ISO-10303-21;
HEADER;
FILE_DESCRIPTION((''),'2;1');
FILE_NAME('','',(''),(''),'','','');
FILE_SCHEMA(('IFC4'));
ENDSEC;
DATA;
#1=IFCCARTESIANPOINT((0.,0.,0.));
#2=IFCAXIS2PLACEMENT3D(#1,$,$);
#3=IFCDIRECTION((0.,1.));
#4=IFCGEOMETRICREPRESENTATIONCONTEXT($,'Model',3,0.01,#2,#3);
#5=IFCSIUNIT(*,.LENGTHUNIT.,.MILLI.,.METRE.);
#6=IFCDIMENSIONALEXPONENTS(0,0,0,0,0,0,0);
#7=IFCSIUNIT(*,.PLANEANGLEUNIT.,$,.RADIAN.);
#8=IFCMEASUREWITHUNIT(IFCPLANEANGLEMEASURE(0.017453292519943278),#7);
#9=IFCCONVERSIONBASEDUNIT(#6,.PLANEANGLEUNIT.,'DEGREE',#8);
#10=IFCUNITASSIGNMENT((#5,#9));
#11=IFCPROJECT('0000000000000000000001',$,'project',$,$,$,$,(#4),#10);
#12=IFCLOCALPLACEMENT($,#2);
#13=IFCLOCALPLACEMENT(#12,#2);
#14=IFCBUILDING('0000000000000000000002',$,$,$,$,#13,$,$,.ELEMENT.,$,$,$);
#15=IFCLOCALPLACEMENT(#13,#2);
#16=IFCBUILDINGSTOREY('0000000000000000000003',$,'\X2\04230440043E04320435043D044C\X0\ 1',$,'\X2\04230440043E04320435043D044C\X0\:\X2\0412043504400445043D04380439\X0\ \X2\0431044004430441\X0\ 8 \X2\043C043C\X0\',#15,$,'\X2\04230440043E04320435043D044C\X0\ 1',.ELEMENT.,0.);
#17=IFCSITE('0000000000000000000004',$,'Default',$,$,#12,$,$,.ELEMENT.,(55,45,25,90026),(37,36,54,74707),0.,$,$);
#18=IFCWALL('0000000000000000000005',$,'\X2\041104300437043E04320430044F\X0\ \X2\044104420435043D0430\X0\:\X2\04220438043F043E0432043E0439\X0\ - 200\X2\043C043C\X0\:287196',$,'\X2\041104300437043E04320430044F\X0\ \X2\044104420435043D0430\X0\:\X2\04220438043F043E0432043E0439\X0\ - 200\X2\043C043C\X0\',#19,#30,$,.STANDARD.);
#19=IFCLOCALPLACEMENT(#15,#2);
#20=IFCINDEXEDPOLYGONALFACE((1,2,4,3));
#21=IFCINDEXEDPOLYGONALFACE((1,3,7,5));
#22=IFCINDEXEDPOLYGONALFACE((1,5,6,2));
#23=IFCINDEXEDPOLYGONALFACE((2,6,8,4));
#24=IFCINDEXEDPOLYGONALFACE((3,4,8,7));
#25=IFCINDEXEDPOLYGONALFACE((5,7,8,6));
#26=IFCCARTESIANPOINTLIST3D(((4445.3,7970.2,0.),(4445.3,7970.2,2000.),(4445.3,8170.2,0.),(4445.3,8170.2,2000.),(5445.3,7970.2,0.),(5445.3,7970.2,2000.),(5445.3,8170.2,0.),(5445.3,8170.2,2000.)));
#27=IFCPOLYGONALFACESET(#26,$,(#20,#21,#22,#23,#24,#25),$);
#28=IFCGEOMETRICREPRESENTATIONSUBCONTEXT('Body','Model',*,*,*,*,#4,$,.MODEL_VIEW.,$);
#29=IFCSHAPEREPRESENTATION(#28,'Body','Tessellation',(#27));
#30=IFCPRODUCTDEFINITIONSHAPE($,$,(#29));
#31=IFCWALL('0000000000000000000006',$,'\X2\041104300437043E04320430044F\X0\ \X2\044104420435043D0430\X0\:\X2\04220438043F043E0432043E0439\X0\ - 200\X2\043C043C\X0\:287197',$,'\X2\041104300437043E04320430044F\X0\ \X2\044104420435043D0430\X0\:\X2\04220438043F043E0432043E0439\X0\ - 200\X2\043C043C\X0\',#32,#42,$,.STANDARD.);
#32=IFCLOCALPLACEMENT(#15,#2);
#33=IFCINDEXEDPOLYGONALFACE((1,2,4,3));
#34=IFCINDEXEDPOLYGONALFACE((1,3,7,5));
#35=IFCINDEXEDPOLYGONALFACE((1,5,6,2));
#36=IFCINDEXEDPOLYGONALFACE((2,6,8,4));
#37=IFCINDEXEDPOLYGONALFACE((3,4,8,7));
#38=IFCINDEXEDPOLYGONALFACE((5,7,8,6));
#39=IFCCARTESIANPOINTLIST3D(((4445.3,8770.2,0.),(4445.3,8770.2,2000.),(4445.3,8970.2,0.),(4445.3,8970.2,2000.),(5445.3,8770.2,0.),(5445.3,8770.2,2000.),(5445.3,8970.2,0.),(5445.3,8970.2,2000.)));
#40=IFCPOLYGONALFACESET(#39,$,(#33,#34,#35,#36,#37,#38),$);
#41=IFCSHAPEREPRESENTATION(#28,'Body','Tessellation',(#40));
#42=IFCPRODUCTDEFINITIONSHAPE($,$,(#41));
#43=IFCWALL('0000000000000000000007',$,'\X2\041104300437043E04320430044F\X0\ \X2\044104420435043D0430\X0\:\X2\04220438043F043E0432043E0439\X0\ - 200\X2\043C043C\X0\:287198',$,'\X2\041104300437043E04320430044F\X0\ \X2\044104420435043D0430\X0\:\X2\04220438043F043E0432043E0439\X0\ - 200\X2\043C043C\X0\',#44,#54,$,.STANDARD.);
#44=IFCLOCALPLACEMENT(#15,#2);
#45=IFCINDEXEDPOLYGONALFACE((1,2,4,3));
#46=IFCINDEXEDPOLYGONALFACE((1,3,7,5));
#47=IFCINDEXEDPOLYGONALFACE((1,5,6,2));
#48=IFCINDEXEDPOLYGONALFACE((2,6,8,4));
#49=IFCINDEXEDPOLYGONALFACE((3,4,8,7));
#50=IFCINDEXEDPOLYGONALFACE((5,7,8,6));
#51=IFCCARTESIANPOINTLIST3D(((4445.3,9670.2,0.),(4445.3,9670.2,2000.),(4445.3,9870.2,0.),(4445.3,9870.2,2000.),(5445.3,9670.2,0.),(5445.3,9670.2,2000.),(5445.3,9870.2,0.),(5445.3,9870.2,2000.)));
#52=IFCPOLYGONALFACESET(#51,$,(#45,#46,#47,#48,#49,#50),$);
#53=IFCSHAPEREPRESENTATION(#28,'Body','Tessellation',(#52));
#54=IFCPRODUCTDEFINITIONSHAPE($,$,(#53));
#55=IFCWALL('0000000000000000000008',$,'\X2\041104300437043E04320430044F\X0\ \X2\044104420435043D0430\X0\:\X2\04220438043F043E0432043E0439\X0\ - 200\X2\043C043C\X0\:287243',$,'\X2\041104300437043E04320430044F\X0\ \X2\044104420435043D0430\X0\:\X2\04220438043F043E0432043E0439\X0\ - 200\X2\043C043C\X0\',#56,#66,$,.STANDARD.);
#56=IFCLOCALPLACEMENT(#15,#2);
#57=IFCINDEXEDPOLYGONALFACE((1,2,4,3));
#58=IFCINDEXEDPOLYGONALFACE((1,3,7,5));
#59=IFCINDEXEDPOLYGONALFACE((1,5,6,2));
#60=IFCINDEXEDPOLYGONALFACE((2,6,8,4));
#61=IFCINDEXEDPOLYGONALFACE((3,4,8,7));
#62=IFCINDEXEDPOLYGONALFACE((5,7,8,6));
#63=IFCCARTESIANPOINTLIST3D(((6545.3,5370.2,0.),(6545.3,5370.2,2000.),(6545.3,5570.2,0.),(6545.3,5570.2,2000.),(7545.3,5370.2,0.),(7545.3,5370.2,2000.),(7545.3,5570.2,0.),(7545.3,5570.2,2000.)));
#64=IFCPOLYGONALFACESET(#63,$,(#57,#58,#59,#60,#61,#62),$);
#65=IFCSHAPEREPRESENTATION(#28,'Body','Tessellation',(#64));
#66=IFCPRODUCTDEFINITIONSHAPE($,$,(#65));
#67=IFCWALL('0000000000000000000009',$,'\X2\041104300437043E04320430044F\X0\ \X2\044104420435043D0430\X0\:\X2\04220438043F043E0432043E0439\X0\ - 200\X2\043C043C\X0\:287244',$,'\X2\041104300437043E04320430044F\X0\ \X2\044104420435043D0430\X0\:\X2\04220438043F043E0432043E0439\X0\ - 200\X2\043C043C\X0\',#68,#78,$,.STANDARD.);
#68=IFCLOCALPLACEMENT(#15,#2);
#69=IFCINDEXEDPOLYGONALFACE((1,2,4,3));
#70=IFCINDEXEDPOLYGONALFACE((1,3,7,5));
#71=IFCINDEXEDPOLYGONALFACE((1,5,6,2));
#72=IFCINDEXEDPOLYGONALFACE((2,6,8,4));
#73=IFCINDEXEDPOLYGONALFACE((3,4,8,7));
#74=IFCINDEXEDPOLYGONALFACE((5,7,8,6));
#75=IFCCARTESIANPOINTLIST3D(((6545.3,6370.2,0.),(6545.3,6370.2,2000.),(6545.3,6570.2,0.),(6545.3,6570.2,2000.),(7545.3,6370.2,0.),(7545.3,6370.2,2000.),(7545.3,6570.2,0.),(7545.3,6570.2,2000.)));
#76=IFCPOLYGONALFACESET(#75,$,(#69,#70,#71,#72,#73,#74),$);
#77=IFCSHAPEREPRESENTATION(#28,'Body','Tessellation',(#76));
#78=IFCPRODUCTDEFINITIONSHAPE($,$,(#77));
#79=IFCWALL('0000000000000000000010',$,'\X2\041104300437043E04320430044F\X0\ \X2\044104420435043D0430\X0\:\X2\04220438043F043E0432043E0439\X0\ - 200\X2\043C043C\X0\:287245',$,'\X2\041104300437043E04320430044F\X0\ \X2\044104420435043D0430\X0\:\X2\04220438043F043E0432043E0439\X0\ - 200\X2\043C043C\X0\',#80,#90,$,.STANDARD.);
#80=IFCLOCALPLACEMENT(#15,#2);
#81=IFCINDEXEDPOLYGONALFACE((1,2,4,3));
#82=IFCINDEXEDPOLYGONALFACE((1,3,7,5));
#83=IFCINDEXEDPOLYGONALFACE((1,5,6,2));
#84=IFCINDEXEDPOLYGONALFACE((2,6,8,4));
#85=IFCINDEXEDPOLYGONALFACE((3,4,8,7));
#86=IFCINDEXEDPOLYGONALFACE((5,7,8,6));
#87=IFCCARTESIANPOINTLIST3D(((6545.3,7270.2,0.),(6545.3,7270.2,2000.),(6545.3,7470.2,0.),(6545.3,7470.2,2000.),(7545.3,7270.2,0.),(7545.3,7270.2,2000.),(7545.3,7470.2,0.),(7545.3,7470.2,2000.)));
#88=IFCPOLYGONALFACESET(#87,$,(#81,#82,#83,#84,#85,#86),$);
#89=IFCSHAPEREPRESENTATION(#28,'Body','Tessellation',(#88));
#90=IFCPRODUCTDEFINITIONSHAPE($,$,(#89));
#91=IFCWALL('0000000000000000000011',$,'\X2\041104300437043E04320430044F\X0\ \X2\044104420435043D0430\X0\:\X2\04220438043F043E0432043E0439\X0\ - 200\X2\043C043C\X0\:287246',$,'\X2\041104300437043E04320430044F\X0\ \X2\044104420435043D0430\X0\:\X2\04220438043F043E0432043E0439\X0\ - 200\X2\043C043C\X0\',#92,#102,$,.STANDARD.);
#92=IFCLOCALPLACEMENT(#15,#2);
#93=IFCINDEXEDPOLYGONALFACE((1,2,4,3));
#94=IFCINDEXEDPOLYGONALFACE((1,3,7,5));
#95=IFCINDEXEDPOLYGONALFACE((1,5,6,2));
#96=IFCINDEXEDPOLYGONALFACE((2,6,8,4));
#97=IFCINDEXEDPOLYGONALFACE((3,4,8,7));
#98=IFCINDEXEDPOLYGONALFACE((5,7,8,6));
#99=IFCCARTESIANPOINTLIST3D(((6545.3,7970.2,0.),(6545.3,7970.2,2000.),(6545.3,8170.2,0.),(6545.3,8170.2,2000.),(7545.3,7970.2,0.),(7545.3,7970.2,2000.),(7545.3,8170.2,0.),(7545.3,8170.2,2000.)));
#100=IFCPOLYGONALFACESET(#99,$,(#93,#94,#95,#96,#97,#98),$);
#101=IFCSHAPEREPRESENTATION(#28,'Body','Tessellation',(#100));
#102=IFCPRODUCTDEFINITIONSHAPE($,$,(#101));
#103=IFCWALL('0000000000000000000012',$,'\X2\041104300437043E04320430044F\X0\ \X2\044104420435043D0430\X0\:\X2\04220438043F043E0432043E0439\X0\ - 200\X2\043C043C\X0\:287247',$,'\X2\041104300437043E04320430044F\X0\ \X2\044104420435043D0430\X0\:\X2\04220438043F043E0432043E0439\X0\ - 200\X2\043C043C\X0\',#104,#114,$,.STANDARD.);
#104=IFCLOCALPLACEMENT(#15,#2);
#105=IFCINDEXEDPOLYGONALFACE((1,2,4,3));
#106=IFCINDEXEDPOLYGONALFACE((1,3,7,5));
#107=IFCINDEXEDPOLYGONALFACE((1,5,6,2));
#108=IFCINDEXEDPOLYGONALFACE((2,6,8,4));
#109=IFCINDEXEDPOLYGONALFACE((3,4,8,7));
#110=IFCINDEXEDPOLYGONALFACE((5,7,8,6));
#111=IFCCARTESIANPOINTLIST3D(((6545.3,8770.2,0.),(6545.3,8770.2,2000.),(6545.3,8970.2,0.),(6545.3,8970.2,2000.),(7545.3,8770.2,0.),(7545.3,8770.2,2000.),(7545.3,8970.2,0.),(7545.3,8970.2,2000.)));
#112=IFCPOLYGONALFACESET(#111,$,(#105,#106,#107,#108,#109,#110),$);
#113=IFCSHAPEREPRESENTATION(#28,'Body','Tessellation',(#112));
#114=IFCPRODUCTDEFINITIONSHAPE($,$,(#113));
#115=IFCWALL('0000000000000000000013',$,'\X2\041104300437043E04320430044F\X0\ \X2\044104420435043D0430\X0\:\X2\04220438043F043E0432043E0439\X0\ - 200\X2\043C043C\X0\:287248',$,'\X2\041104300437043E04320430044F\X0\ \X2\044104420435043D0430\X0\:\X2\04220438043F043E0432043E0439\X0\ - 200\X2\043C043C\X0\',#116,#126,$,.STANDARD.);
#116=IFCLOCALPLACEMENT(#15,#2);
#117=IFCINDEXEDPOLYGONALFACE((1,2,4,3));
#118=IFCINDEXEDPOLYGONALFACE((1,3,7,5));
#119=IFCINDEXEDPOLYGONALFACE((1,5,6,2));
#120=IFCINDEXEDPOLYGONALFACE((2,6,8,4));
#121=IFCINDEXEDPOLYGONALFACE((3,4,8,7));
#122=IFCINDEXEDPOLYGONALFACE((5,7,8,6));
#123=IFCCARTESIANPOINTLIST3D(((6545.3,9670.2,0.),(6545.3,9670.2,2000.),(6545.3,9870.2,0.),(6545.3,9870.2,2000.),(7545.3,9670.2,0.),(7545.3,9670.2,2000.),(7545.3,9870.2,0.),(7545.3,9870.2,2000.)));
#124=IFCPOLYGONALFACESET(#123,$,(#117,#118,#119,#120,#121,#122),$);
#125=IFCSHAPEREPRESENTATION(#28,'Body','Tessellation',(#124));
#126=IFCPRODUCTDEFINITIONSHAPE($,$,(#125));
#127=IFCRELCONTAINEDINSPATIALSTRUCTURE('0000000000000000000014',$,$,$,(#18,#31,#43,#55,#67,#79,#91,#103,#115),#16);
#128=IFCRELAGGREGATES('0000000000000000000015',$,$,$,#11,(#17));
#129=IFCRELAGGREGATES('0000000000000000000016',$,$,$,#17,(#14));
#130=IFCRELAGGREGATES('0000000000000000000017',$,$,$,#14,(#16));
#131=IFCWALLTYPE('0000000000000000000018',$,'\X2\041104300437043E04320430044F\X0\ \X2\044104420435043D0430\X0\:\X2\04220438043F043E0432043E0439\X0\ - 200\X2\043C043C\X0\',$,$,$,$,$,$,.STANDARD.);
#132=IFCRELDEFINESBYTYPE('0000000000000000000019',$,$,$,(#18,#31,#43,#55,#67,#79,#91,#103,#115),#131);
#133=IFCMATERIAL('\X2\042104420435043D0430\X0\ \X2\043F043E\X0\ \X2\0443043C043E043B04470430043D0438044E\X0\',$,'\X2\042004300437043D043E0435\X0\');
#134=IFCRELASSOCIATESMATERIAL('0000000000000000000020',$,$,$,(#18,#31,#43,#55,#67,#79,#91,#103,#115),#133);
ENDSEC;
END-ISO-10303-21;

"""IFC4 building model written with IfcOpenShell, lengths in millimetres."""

from ifc_helpers import new_model, entity, si_unit, converted_unit, direction, frame, origin, place, context, subcontext, project, spatial, indexed_curve, outline, extrude, material, type_object, element, save


model = new_model("IFC4")

# Units and contexts
model_context = context("Model", 3, precision=0.01, world=origin(), true_north=direction((0.0, 1.0)))
body_context = subcontext(model_context, "Body", "Model", "MODEL_VIEW")
ifc_project = project(units=[si_unit("LENGTHUNIT", "METRE", prefix="MILLI"), converted_unit("PLANEANGLEUNIT", "DEGREE", entity("IfcPlaneAngleMeasure", 0.017453292519943278), si_unit("PLANEANGLEUNIT", "RADIAN"), dimensions=[0, 0, 0, 0, 0, 0, 0])], contexts=[model_context])

# Site, building, storey
site_placement = place(None, origin())
site = spatial("IfcSite", under=ifc_project, at=site_placement, Name="Default", CompositionType="ELEMENT", RefLatitude=(55, 45, 25, 90026), RefLongitude=(37, 36, 54, 74707), RefElevation=0.0)
building_placement = place(site_placement, origin())
building = spatial("IfcBuilding", under=site, at=building_placement, CompositionType="ELEMENT")
storey_placement = place(building_placement, origin())
storey = spatial("IfcBuildingStorey", under=building, at=storey_placement, Name="Уровень 1", ObjectType="Уровень:Верхний брус 8 мм", LongName="Уровень 1", CompositionType="ELEMENT", Elevation=0.0)

# Walls
ifc_material = material(Name="Стена по умолчанию", Category="Разное")
wall_type = type_object("IfcWallType", Name="Базовая стена:Типовой - 200мм", PredefinedType="STANDARD")
for number, where, name in (
    (1, (4445.3, 8070.2, 0.0), "Базовая стена:Типовой - 200мм:287196"),
):
    element("IfcWall", number, at=place(storey_placement, frame(where)), inside=storey, type_object=wall_type, material=ifc_material, Name=name, ObjectType="Базовая стена:Типовой - 200мм", PredefinedType="STANDARD", context=body_context, shape_type="SweptSolid", body=[
        extrude(outline(indexed_curve([(1000.0, 100.0), (0.0, 100.0), (0.0, -100.0), (1000.0, -100.0), (1000.0, 100.0)], self_intersect=False)), origin(), (0.0, 0.0, 1.0), 2000.0),
    ])
wall_1_placement = place(storey_placement, frame((4445.3, 8870.2, 0.0)))
element("IfcWall", 2, at=wall_1_placement, inside=storey, type_object=wall_type, material=ifc_material, Name="Базовая стена:Типовой - 200мм:287197", ObjectType="Базовая стена:Типовой - 200мм", PredefinedType="STANDARD", context=body_context, shape_type="SweptSolid", body=[
    extrude(outline(indexed_curve([(1000.0, 100.0), (0.0, 100.0), (0.0, -100.0), (1000.0, -100.0), (1000.0, 100.0)], self_intersect=False)), origin(), (0.0, 0.0, 1.0), 2000.0),
])
wall_2_placement = place(storey_placement, frame((4445.3, 9770.2, 0.0)))
element("IfcWall", 3, at=wall_2_placement, inside=storey, type_object=wall_type, material=ifc_material, Name="Базовая стена:Типовой - 200мм:287198", ObjectType="Базовая стена:Типовой - 200мм", PredefinedType="STANDARD", context=body_context, shape_type="SweptSolid", body=[
    extrude(outline(indexed_curve([(1000.0, 100.0), (0.0, 100.0), (0.0, -100.0), (1000.0, -100.0), (1000.0, 100.0)], self_intersect=False)), origin(), (0.0, 0.0, 1.0), 2000.0),
])
for number, where, name in (
    (4, (6545.3, 5470.2, 0.0), "Базовая стена:Типовой - 200мм:287243"),
    (5, (6545.3, 6470.2, 0.0), "Базовая стена:Типовой - 200мм:287244"),
):
    element("IfcWall", number, at=place(storey_placement, frame(where)), inside=storey, type_object=wall_type, material=ifc_material, Name=name, ObjectType="Базовая стена:Типовой - 200мм", PredefinedType="STANDARD", context=body_context, shape_type="SweptSolid", body=[
        extrude(outline(indexed_curve([(1000.0, 100.0), (0.0, 100.0), (0.0, -100.0), (1000.0, -100.0), (1000.0, 100.0)], self_intersect=False)), origin(), (0.0, 0.0, 1.0), 2000.0),
    ])
for number, where, name in (
    (6, (6545.3, 7370.2, 0.0), "Базовая стена:Типовой - 200мм:287245"),
    (7, (6545.3, 8070.2, 0.0), "Базовая стена:Типовой - 200мм:287246"),
):
    element("IfcWall", number, at=place(storey_placement, frame(where)), inside=storey, type_object=wall_type, material=ifc_material, Name=name, ObjectType="Базовая стена:Типовой - 200мм", PredefinedType="STANDARD", context=body_context, shape_type="SweptSolid", body=[
        extrude(outline(indexed_curve([(1000.0, 100.0), (0.0, 100.0), (0.0, -100.0), (1000.0, -100.0), (1000.0, 100.0)], self_intersect=False)), origin(), (0.0, 0.0, 1.0), 2000.0),
    ])
wall_3_placement = place(storey_placement, frame((6545.3, 8870.2, 0.0)))
element("IfcWall", 8, at=wall_3_placement, inside=storey, type_object=wall_type, material=ifc_material, Name="Базовая стена:Типовой - 200мм:287247", ObjectType="Базовая стена:Типовой - 200мм", PredefinedType="STANDARD", context=body_context, shape_type="SweptSolid", body=[
    extrude(outline(indexed_curve([(1000.0, 100.0), (0.0, 100.0), (0.0, -100.0), (1000.0, -100.0), (1000.0, 100.0)], self_intersect=False)), origin(), (0.0, 0.0, 1.0), 2000.0),
])
wall_4_placement = place(storey_placement, frame((6545.3, 9770.2, 0.0)))
element("IfcWall", 9, at=wall_4_placement, inside=storey, type_object=wall_type, material=ifc_material, Name="Базовая стена:Типовой - 200мм:287248", ObjectType="Базовая стена:Типовой - 200мм", PredefinedType="STANDARD", context=body_context, shape_type="SweptSolid", body=[
    extrude(outline(indexed_curve([(1000.0, 100.0), (0.0, 100.0), (0.0, -100.0), (1000.0, -100.0), (1000.0, 100.0)], self_intersect=False)), origin(), (0.0, 0.0, 1.0), 2000.0),
])

save(model, "model.ifc")
